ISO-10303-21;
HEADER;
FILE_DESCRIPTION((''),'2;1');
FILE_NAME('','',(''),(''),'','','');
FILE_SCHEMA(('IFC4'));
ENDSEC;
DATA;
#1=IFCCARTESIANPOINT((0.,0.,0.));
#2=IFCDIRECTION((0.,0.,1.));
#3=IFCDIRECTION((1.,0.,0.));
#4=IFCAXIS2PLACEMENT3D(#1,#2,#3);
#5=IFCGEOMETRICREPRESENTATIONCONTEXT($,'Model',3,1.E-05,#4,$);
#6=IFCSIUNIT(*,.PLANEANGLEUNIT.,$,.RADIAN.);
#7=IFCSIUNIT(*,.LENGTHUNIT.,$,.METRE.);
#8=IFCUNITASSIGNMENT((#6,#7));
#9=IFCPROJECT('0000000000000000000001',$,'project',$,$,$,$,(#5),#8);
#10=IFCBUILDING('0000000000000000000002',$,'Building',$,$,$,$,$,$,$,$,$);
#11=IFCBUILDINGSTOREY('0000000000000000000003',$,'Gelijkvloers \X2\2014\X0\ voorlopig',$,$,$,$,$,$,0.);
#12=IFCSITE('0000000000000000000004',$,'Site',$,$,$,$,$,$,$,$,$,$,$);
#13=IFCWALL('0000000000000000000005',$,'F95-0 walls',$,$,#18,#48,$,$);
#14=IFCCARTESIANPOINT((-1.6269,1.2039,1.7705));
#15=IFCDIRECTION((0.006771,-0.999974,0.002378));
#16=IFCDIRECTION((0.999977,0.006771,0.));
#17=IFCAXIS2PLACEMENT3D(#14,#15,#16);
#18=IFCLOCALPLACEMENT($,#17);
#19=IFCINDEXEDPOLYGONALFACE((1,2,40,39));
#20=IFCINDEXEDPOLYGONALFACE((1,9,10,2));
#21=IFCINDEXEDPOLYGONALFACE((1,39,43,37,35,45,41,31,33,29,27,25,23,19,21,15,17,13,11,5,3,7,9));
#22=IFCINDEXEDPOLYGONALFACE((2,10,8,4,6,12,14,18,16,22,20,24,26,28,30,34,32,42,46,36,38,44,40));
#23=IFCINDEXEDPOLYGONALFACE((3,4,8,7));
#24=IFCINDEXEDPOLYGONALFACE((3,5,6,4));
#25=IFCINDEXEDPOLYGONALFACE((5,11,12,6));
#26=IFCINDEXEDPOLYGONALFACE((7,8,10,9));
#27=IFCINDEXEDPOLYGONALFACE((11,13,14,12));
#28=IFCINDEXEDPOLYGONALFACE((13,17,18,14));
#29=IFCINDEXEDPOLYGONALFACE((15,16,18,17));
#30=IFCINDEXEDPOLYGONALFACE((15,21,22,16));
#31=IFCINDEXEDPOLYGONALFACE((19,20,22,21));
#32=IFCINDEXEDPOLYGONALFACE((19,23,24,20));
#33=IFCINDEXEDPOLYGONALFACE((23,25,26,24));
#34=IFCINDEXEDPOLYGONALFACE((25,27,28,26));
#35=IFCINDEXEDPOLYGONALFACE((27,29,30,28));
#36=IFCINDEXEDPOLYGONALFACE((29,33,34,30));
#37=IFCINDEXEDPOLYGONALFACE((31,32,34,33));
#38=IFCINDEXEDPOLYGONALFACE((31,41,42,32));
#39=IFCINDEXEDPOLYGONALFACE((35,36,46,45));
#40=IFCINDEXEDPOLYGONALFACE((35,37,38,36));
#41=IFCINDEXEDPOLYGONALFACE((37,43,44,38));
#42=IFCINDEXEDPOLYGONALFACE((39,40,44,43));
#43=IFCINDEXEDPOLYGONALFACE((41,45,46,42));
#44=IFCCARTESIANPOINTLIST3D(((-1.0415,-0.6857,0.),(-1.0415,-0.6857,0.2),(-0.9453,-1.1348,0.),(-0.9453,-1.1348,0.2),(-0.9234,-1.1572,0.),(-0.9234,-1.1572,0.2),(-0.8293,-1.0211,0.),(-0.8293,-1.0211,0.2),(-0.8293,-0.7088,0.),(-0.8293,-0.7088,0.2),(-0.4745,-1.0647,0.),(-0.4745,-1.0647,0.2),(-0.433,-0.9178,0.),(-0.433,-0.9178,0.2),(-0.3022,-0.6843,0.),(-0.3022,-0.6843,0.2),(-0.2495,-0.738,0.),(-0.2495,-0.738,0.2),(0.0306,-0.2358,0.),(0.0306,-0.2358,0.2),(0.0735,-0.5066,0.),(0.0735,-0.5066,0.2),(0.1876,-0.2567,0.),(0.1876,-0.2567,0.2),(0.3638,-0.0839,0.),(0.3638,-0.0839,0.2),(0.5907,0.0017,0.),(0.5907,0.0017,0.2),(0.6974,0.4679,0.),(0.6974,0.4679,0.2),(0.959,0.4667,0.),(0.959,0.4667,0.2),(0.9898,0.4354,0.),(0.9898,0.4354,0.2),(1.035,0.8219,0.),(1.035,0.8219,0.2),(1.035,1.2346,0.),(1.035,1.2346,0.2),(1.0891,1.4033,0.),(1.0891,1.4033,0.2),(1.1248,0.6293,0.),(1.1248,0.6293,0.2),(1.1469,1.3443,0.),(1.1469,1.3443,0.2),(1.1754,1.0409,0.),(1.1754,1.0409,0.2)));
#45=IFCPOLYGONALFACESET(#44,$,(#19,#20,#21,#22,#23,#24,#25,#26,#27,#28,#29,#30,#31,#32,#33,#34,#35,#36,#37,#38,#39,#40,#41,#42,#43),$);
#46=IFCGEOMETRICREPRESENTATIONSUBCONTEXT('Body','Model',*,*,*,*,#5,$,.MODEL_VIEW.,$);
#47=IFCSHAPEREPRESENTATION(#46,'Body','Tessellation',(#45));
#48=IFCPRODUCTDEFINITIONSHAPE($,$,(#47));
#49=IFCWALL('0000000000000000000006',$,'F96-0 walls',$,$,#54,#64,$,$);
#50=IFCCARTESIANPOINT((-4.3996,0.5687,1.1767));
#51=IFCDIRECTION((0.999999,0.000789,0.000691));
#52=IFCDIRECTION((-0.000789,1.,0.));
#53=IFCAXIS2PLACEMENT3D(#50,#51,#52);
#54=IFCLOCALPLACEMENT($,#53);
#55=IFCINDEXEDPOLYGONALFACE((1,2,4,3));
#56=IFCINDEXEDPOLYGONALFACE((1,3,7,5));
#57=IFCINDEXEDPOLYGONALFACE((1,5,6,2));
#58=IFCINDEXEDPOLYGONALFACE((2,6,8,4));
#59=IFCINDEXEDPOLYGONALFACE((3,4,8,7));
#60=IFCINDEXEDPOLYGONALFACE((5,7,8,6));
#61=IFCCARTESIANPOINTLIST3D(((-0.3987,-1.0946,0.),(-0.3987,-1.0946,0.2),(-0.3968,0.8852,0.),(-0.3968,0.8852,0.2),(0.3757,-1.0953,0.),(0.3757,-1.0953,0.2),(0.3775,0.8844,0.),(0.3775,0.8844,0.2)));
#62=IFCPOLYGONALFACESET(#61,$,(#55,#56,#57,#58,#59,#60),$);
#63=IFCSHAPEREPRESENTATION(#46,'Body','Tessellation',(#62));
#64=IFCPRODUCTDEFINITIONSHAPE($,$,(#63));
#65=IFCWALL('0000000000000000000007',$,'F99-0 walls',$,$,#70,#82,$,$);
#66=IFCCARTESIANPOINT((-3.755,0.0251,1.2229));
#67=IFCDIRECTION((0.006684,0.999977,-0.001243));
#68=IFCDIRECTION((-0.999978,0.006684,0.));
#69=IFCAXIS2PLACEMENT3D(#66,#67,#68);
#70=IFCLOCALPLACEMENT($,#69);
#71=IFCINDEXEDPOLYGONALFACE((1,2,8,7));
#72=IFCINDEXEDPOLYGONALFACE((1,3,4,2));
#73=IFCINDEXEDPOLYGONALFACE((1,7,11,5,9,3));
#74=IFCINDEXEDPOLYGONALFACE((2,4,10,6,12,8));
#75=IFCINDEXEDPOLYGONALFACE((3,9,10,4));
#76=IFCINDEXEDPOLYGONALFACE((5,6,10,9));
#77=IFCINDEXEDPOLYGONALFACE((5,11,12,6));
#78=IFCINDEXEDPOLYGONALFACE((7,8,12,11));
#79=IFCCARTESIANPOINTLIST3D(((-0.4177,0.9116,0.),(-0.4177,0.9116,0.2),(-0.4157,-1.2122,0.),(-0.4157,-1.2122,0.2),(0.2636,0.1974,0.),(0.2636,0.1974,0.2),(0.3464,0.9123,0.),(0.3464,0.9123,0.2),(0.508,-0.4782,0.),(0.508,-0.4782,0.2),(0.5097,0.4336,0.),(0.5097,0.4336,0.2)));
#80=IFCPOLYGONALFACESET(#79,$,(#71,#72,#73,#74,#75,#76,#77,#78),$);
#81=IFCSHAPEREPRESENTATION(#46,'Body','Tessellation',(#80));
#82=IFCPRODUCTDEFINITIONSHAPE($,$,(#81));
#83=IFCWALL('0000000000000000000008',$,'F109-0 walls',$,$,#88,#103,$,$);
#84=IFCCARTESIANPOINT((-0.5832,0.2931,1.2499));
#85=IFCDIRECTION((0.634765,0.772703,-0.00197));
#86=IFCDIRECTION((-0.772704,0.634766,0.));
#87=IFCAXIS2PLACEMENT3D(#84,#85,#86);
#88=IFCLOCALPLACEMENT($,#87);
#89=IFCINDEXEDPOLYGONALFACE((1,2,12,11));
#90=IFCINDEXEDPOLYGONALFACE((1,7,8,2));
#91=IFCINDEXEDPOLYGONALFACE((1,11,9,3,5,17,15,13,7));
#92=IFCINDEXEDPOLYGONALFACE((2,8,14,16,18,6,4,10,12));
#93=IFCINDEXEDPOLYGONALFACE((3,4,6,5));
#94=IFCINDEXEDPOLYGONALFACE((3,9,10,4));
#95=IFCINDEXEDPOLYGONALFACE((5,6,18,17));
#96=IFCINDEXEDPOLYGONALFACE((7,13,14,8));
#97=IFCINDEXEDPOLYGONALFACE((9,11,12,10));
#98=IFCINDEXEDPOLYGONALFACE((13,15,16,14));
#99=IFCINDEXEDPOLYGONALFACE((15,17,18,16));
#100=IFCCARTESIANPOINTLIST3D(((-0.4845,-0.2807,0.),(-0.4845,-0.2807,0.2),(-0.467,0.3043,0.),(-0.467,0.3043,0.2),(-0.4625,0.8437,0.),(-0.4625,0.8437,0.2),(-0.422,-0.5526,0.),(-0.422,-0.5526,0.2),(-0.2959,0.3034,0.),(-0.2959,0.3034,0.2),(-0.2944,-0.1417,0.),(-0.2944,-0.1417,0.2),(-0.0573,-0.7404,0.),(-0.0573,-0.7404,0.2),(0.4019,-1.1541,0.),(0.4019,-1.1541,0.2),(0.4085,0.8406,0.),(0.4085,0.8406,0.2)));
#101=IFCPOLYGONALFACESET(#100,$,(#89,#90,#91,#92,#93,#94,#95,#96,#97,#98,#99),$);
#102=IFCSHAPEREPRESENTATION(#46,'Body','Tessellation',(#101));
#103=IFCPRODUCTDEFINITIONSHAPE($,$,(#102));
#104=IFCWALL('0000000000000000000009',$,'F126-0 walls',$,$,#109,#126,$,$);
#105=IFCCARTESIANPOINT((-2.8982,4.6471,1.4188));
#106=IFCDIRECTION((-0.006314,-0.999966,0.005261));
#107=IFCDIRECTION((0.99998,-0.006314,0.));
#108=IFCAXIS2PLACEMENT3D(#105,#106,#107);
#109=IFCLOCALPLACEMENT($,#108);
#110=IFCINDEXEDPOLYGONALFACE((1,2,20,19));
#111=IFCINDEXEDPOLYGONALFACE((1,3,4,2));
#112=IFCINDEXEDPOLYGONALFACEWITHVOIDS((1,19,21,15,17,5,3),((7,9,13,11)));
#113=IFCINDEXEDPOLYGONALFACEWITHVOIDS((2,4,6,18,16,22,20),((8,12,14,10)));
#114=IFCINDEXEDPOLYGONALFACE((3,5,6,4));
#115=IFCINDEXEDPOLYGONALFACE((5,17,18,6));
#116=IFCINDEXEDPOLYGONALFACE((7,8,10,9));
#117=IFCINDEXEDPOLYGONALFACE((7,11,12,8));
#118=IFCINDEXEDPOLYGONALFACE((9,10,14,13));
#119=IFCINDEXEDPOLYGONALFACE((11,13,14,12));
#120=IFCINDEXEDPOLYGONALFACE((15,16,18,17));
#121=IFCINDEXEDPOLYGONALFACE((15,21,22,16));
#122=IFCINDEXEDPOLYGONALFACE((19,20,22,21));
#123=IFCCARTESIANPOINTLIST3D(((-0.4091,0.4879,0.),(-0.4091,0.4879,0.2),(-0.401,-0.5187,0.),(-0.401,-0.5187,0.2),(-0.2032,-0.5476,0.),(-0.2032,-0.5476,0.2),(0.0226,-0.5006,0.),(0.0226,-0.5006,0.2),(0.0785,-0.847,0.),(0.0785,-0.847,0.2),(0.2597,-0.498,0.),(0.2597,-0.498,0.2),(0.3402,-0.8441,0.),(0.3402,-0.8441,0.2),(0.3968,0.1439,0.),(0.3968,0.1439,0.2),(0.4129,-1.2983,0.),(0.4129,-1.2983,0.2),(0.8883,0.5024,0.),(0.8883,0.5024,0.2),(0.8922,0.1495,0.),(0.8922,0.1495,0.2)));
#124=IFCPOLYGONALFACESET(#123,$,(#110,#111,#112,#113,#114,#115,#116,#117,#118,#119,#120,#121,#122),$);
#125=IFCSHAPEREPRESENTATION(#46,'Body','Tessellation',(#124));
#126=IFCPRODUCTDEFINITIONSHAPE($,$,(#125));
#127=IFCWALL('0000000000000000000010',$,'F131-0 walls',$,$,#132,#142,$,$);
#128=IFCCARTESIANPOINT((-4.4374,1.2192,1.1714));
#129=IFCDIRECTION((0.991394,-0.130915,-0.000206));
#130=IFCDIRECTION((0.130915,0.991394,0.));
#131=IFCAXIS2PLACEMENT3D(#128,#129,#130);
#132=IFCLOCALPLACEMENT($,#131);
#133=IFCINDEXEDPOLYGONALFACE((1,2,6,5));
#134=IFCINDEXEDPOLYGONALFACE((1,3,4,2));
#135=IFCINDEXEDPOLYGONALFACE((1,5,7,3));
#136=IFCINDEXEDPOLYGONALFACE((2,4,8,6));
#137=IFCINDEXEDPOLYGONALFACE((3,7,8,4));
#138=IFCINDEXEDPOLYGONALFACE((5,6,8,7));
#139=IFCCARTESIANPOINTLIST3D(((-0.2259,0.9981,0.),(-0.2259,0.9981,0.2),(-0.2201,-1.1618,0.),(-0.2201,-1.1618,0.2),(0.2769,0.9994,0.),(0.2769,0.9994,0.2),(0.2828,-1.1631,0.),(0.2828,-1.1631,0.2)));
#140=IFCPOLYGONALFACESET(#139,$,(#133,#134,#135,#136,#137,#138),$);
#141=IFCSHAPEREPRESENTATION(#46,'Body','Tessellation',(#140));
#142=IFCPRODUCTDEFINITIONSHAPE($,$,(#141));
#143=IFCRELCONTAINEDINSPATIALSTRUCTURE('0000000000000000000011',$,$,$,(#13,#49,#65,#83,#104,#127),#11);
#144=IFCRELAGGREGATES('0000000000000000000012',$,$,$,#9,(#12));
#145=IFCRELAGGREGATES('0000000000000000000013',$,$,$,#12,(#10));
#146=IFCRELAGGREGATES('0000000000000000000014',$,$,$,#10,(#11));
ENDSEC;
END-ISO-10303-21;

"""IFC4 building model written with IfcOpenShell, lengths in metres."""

from ifc_helpers import new_model, si_unit, frame, origin_with_axes, place, context, subcontext, project, spatial, polyline, outline, extrude, element, save


model = new_model("IFC4")

# Units and contexts
model_context = context("Model", 3, precision=1e-05, world=origin_with_axes())
body_context = subcontext(model_context, "Body", "Model", "MODEL_VIEW")
ifc_project = project(units=[si_unit("PLANEANGLEUNIT", "RADIAN"), si_unit("LENGTHUNIT", "METRE")], contexts=[model_context])

# Site, building, storey
site = spatial("IfcSite", under=ifc_project, Name="Site")
building = spatial("IfcBuilding", under=site, Name="Building")
storey = spatial("IfcBuildingStorey", under=building, Name="Gelijkvloers — voorlopig", Elevation=0.0)

# Walls
wall_1_placement = place(None, frame((-1.6269, 1.2039, 1.7705), z_axis=(0.006771, -0.999974, 0.002378), x_axis=(0.999977, 0.006771, 0.0)))
element("IfcWall", 1, at=wall_1_placement, inside=storey, Name="F95-0 walls", context=body_context, shape_type="SweptSolid", body=[
    extrude(outline(polyline([(-0.9234, -1.1572), (-0.4745, -1.0647), (-0.433, -0.9178), (-0.2495, -0.738), (-0.3022, -0.6843), (0.0735, -0.5066), (0.0306, -0.2358), (0.1876, -0.2567), (0.3638, -0.0839), (0.5907, 0.0017), (0.6974, 0.4679), (0.9898, 0.4354), (0.959, 0.4667), (1.1248, 0.6293), (1.1754, 1.0409), (1.035, 0.8219), (1.035, 1.2346), (1.1469, 1.3443), (1.0891, 1.4033), (-1.0415, -0.6857), (-0.8293, -0.7088), (-0.8293, -1.0211), (-0.9453, -1.1348), (-0.9234, -1.1572)])), origin_with_axes(), (0.0, 0.0, 1.0), 0.2),
])
wall_2_placement = place(None, frame((-4.3996, 0.5687, 1.1767), z_axis=(0.999999, 0.000789, 0.000691), x_axis=(-0.000789, 1.0, 0.0)))
element("IfcWall", 2, at=wall_2_placement, inside=storey, Name="F96-0 walls", context=body_context, shape_type="SweptSolid", body=[
    extrude(outline(polyline([(-0.3987, -1.0946), (0.3757, -1.0953), (0.3775, 0.8844), (-0.3968, 0.8852), (-0.3987, -1.0946)])), origin_with_axes(), (0.0, 0.0, 1.0), 0.2),
])
wall_3_placement = place(None, frame((-3.755, 0.0251, 1.2229), z_axis=(0.006684, 0.999977, -0.001243), x_axis=(-0.999978, 0.006684, 0.0)))
element("IfcWall", 3, at=wall_3_placement, inside=storey, Name="F99-0 walls", context=body_context, shape_type="SweptSolid", body=[
    extrude(outline(polyline([(-0.4157, -1.2122), (0.508, -0.4782), (0.2636, 0.1974), (0.5097, 0.4336), (0.3464, 0.9123), (-0.4177, 0.9116), (-0.4157, -1.2122)])), origin_with_axes(), (0.0, 0.0, 1.0), 0.2),
])
wall_4_placement = place(None, frame((-0.5832, 0.2931, 1.2499), z_axis=(0.634765, 0.772703, -0.00197), x_axis=(-0.772704, 0.634766, 0.0)))
element("IfcWall", 4, at=wall_4_placement, inside=storey, Name="F109-0 walls", context=body_context, shape_type="SweptSolid", body=[
    extrude(outline(polyline([(0.4019, -1.1541), (0.4085, 0.8406), (-0.4625, 0.8437), (-0.467, 0.3043), (-0.2959, 0.3034), (-0.2944, -0.1417), (-0.4845, -0.2807), (-0.422, -0.5526), (-0.0573, -0.7404), (0.4019, -1.1541)])), origin_with_axes(), (0.0, 0.0, 1.0), 0.2),
])

# Wall, opening
wall_5_placement = place(None, frame((-2.8982, 4.6471, 1.4188), z_axis=(-0.006314, -0.999966, 0.005261), x_axis=(0.99998, -0.006314, 0.0)))
wall_5 = element("IfcWall", 5, at=wall_5_placement, inside=storey, Name="F126-0 walls", context=body_context, shape_type="SweptSolid", body=[
    extrude(outline(polyline([(0.4129, -1.2983), (0.3968, 0.1439), (0.8922, 0.1495), (0.8883, 0.5024), (-0.4091, 0.4879), (-0.401, -0.5187), (-0.2032, -0.5476), (0.4129, -1.2983)])), origin_with_axes(), (0.0, 0.0, 1.0), 0.2),
])
opening_1_placement = place(wall_5_placement, frame((0.0, 0.0, -0.05), z_axis=(0.0, 0.0, 1.0), x_axis=(1.0, 0.0, 0.0)))
element("IfcOpeningElement", 6, at=opening_1_placement, cuts=wall_5, PredefinedType="OPENING", context=body_context, shape_type="SweptSolid", body=[
    extrude(outline(polyline([(0.0785, -0.847), (0.0226, -0.5006), (0.2597, -0.498), (0.3402, -0.8441), (0.0785, -0.847)])), origin_with_axes(), (0.0, 0.0, 1.0), 0.3),
])

# Wall
wall_6_placement = place(None, frame((-4.4374, 1.2192, 1.1714), z_axis=(0.991394, -0.130915, -0.000206), x_axis=(0.130915, 0.991394, 0.0)))
element("IfcWall", 7, at=wall_6_placement, inside=storey, Name="F131-0 walls", context=body_context, shape_type="SweptSolid", body=[
    extrude(outline(polyline([(-0.2201, -1.1618), (0.2828, -1.1631), (0.2769, 0.9994), (-0.2259, 0.9981), (-0.2201, -1.1618)])), origin_with_axes(), (0.0, 0.0, 1.0), 0.2),
])

save(model, "model.ifc")
